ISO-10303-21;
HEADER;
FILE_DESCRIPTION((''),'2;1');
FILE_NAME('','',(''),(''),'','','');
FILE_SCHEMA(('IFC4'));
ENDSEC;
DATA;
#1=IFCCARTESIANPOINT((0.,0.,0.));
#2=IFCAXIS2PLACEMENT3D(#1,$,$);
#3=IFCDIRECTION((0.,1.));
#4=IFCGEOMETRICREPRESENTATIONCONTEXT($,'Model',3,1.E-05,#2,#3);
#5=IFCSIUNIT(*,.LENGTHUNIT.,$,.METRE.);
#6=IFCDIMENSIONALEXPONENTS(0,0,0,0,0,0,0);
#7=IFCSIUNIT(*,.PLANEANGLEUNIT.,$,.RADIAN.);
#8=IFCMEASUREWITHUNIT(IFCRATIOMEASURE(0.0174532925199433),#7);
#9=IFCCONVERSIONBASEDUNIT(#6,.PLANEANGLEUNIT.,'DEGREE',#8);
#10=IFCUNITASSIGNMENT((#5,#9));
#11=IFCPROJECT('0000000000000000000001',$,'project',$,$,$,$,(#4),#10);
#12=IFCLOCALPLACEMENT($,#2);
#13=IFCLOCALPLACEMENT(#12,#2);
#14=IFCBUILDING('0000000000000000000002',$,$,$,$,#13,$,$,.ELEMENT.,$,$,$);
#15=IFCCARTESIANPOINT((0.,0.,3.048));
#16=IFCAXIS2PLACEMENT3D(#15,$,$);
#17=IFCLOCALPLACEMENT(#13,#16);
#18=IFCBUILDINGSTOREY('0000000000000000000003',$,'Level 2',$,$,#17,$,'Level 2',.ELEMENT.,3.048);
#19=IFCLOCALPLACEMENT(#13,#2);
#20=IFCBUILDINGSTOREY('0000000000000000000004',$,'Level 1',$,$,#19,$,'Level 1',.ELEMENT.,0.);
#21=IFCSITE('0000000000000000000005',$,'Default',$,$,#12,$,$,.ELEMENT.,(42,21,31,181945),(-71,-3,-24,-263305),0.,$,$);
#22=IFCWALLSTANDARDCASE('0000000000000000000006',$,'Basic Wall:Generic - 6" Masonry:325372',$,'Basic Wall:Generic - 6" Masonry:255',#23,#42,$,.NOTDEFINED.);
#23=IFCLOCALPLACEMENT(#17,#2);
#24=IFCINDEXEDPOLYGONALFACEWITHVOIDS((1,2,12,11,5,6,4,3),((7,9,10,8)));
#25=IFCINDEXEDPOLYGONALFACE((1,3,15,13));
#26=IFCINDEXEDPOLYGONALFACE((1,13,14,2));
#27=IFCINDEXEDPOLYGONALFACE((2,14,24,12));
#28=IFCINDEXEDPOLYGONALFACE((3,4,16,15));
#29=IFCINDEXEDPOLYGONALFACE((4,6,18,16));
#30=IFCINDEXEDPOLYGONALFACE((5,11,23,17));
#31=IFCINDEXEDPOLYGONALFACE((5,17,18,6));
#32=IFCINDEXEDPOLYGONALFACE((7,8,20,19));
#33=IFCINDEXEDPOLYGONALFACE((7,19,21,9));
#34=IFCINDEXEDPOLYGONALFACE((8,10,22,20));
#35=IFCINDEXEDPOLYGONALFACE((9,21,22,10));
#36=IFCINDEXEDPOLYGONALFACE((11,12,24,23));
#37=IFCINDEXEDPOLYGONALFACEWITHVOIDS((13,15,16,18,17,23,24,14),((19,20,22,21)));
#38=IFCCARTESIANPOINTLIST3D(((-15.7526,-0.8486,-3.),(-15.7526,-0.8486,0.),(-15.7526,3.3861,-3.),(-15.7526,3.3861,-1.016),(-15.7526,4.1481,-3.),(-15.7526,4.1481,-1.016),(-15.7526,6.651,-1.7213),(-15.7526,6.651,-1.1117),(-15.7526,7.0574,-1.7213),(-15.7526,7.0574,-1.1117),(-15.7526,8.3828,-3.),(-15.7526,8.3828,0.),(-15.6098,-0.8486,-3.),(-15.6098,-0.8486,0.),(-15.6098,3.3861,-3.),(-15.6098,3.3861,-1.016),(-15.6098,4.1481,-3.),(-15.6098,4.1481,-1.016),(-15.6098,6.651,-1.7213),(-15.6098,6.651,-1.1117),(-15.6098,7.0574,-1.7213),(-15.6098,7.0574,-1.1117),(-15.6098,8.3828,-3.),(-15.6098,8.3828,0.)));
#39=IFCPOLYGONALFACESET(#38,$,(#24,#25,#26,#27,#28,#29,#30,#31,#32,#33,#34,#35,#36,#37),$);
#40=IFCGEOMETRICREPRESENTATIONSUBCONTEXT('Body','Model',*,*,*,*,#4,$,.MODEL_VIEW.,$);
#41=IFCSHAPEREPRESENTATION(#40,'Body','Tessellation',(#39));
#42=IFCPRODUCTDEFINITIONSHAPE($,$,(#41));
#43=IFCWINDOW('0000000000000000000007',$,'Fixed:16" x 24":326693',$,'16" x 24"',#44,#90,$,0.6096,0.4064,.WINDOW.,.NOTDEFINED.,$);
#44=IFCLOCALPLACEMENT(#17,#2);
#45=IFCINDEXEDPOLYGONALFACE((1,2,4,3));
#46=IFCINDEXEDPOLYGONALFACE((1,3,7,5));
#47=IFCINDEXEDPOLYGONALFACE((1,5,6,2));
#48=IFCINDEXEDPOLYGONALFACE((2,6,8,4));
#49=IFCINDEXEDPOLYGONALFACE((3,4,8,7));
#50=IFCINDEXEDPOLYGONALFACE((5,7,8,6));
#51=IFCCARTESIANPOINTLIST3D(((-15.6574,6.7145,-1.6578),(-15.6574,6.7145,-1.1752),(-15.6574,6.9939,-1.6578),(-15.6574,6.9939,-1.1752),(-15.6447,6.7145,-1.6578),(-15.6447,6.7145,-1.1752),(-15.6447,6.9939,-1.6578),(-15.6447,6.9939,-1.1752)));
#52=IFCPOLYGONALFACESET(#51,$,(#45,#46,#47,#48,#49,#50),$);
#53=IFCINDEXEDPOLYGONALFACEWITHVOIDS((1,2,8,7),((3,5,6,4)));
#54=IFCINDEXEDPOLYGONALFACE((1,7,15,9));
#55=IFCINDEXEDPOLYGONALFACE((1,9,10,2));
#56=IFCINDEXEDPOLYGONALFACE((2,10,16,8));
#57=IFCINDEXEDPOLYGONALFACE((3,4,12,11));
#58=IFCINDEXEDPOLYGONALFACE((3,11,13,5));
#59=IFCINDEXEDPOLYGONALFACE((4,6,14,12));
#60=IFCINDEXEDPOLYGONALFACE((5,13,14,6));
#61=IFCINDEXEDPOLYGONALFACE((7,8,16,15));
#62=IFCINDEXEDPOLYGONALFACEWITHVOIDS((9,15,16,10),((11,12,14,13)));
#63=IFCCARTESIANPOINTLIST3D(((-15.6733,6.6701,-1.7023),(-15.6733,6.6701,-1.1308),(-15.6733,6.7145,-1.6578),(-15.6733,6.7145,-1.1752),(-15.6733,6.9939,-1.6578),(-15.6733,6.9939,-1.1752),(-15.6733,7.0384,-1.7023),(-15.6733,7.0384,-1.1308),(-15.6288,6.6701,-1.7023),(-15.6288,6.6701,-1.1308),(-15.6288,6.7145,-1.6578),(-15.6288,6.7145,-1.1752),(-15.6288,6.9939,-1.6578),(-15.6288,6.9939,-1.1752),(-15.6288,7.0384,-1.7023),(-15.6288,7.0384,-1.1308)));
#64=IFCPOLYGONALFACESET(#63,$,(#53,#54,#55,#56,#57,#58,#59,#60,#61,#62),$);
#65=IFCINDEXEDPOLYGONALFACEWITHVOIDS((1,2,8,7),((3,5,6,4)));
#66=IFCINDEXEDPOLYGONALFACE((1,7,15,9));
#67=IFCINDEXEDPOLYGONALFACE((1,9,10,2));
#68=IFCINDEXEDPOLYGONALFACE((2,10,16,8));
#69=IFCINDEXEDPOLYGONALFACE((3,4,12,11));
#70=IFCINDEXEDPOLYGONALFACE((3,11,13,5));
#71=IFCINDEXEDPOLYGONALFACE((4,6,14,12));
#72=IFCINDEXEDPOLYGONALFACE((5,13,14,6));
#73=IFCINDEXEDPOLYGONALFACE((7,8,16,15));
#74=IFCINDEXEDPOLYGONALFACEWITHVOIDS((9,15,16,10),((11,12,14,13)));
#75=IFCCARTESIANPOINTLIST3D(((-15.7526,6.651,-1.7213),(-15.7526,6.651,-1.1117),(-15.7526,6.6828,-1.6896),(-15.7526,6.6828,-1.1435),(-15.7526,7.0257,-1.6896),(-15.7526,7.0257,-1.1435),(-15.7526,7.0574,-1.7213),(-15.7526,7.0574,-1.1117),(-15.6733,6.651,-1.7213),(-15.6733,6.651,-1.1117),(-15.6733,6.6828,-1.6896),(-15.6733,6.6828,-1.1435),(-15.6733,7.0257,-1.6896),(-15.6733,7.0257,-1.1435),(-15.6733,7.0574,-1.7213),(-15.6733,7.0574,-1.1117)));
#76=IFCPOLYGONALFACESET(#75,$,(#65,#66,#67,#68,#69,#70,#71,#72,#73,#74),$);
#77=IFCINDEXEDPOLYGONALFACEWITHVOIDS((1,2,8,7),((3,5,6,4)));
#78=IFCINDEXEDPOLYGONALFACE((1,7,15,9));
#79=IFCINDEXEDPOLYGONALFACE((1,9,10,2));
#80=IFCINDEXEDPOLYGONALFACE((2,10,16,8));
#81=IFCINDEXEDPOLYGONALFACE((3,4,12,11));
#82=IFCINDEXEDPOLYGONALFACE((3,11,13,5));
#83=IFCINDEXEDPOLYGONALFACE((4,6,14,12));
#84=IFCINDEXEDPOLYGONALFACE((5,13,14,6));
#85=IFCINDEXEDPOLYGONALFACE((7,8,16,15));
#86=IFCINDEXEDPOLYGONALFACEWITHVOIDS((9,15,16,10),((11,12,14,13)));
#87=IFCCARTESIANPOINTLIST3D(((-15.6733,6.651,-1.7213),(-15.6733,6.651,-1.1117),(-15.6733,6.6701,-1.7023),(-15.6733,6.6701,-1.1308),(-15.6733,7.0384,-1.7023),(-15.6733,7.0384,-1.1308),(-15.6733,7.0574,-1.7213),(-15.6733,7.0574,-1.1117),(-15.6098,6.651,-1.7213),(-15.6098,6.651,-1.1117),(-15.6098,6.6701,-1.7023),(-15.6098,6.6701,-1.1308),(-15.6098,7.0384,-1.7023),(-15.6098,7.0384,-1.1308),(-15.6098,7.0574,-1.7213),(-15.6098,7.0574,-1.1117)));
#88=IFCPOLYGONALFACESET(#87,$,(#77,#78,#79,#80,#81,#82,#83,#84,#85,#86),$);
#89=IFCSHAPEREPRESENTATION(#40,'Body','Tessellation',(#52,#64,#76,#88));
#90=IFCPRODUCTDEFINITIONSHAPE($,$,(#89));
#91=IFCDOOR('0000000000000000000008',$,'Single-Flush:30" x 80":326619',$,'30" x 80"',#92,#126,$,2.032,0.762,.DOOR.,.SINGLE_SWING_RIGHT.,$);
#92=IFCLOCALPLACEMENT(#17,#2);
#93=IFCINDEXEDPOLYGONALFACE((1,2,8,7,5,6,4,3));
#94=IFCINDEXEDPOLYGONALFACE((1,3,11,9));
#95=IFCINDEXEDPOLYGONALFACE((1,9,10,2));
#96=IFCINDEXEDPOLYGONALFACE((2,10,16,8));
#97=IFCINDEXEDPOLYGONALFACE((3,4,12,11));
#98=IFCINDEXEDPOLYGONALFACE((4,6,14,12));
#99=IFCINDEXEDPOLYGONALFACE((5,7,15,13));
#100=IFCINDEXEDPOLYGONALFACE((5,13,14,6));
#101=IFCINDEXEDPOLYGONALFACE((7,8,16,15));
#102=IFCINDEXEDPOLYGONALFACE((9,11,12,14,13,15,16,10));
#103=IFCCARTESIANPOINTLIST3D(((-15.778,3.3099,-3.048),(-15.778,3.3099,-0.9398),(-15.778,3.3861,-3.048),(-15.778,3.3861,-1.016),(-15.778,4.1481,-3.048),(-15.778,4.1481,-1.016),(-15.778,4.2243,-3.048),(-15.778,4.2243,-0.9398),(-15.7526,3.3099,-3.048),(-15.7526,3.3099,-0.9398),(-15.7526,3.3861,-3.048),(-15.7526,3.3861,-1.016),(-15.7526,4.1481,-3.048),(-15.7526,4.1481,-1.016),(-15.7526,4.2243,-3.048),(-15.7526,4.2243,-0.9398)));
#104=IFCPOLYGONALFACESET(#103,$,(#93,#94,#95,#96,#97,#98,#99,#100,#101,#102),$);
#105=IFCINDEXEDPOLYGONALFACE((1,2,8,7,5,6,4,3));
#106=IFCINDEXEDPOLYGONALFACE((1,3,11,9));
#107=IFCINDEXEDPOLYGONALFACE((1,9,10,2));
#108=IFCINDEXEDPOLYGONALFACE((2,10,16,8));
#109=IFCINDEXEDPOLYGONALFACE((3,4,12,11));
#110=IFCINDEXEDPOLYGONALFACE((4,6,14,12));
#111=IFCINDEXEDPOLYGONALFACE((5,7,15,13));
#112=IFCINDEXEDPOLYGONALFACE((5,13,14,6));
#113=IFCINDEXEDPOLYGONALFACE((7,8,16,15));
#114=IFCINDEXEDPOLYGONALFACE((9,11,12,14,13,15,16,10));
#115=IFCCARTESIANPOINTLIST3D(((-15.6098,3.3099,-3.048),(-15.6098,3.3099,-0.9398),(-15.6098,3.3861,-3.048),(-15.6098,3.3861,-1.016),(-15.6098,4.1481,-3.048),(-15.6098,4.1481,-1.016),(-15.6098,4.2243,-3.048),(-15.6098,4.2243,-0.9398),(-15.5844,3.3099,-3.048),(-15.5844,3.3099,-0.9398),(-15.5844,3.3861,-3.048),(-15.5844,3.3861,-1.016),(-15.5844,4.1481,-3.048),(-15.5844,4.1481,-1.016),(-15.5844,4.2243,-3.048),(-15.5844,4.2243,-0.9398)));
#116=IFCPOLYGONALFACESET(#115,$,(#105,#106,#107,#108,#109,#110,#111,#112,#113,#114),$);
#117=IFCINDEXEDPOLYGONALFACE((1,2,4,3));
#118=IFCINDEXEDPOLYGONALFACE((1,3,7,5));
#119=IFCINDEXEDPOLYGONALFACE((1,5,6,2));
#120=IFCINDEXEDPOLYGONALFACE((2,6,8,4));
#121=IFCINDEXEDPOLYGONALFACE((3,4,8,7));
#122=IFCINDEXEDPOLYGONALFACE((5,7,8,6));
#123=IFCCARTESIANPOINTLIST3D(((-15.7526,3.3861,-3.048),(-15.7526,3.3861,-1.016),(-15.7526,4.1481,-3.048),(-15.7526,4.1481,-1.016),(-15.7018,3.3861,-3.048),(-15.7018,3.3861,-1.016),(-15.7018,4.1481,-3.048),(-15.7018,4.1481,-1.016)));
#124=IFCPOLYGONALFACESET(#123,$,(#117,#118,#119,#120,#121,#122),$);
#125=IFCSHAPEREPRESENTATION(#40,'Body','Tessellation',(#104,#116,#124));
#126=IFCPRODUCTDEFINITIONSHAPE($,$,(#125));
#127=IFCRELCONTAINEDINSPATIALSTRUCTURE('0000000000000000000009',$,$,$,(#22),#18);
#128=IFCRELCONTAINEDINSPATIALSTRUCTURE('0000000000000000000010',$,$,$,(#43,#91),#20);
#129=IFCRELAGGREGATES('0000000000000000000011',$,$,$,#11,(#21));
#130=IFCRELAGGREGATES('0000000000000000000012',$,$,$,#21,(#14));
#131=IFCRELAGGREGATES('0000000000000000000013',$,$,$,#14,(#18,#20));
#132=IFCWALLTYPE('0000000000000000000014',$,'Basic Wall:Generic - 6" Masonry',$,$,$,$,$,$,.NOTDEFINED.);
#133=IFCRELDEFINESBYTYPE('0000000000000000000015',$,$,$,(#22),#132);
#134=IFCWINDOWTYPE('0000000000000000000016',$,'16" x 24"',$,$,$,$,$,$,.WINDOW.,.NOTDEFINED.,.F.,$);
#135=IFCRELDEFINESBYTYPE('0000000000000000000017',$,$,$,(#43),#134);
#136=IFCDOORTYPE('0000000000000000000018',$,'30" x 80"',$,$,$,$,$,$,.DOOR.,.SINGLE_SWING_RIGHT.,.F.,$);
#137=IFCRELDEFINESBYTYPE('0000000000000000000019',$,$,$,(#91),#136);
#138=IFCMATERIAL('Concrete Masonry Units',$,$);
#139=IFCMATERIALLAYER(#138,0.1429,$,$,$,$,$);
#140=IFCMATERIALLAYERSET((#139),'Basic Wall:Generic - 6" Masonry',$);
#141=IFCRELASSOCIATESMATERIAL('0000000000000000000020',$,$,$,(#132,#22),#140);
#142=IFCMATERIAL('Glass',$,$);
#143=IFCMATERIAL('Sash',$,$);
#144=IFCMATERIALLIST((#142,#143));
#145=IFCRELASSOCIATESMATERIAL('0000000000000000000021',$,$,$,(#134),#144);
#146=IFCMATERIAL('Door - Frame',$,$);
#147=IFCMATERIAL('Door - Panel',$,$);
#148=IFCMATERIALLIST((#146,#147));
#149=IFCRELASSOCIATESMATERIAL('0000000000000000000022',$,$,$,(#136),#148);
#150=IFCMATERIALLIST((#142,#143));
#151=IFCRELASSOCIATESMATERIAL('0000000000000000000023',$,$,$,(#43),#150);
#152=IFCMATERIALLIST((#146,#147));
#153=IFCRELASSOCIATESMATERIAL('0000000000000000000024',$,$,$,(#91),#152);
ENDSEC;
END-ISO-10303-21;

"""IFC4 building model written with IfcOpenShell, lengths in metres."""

from ifc_helpers import new_model, entity, si_unit, converted_unit, direction, frame, frame_2d, origin, place, context, subcontext, project, spatial, polyline, rectangle, outline, extrude, source, transform, mapped, material, material_list, layer, layer_set, layer_usage, type_object, type_shapes, element, fill, save


model = new_model("IFC4")

# Units and contexts
model_context = context("Model", 3, precision=1e-05, world=origin(), true_north=direction((0.0, 1.0)))
body_context = subcontext(model_context, "Body", "Model", "MODEL_VIEW")
ifc_project = project(units=[si_unit("LENGTHUNIT", "METRE"), converted_unit("PLANEANGLEUNIT", "DEGREE", entity("IfcRatioMeasure", 0.0174532925199433), si_unit("PLANEANGLEUNIT", "RADIAN"), dimensions=[0, 0, 0, 0, 0, 0, 0])], contexts=[model_context])

# Site, building, storey
site_placement = place(None, origin())
site = spatial("IfcSite", under=ifc_project, at=site_placement, Name="Default", CompositionType="ELEMENT", RefLatitude=(42, 21, 31, 181945), RefLongitude=(-71, -3, -24, -263305), RefElevation=0.0)
building_placement = place(site_placement, origin())
building = spatial("IfcBuilding", under=site, at=building_placement, CompositionType="ELEMENT")
storey_1_placement = place(building_placement, frame((0.0, 0.0, 3.048)))
storey_1 = spatial("IfcBuildingStorey", under=building, at=storey_1_placement, Name="Level 2", LongName="Level 2", CompositionType="ELEMENT", Elevation=3.048)

# Shared definitions
ifc_material_1 = material(Name="Concrete Masonry Units")
ifc_layer = layer(ifc_material_1, 0.1429)
ifc_layer_set = layer_set([ifc_layer], Name="Basic Wall:Generic - 6\" Masonry")
wall_type = type_object("IfcWallType", Name="Basic Wall:Generic - 6\" Masonry", PredefinedType="NOTDEFINED", material=ifc_layer_set)

# Shared definitions
storey_2_placement = place(building_placement, origin())
storey_2 = spatial("IfcBuildingStorey", under=building, at=storey_2_placement, Name="Level 1", LongName="Level 1", CompositionType="ELEMENT", Elevation=0.0)

# Shared definitions
ifc_material_2 = material(Name="Glass")
ifc_material_3 = material(Name="Sash")
ifc_material_list_1 = material_list([ifc_material_2, ifc_material_3])
window_type = type_object("IfcWindowType", Name="16\" x 24\"", ParameterTakesPrecedence=False, PartitioningType="NOTDEFINED", PredefinedType="WINDOW", material=ifc_material_list_1)
shared_shape_1 = source(origin(), body_context, "Body", "SweptSolid", [
    extrude(rectangle(XDim=0.0127, YDim=0.2794, at=frame_2d((0.0, 0.0), x_axis=(1.0, 0.0))), frame((0.2032, 0.1016, 0.0635), z_axis=(0.0, 0.0, 1.0), x_axis=(0.0, 1.0, 0.0)), (0.0, 0.0, 1.0), 0.4826),
    extrude(outline(polyline([(-0.1841, -0.2858), (0.1841, -0.2858), (0.1841, 0.2858), (-0.1841, 0.2858), (-0.1841, -0.2858)]), holes=[polyline([(-0.1397, -0.2413), (-0.1397, 0.2413), (0.1397, 0.2413), (0.1397, -0.2413), (-0.1397, -0.2413)])]), frame((0.2032, 0.0794, 0.3048), z_axis=(0.0, 1.0, 0.0), x_axis=(1.0, 0.0, 0.0)), (0.0, 0.0, 1.0), 0.0445),
    extrude(outline(polyline([(-0.2032, -0.3048), (0.2032, -0.3048), (0.2032, 0.3048), (-0.2032, 0.3048), (-0.2032, -0.3048)]), holes=[polyline([(-0.1715, -0.273), (-0.1715, 0.2731), (0.1714, 0.2731), (0.1714, -0.273), (-0.1715, -0.273)])]), frame((0.2032, 0.0, 0.3048), z_axis=(0.0, 1.0, 0.0), x_axis=(1.0, 0.0, 0.0)), (0.0, 0.0, 1.0), 0.0794),
    extrude(outline(polyline([(-0.3048, -0.2032), (0.3048, -0.2032), (0.3048, 0.2032), (-0.3048, 0.2032), (-0.3048, -0.2032)]), holes=[polyline([(-0.2857, -0.1841), (-0.2857, 0.1842), (0.2858, 0.1842), (0.2858, -0.1841), (-0.2857, -0.1841)])]), frame((0.2032, 0.0794, 0.3048), z_axis=(0.0, 1.0, 0.0), x_axis=(0.0, 0.0, -1.0)), (0.0, 0.0, 1.0), 0.0635),
])
type_shapes(window_type, [shared_shape_1])

# Shared definitions
ifc_material_4 = material(Name="Door - Frame")
ifc_material_5 = material(Name="Door - Panel")
ifc_material_list_2 = material_list([ifc_material_4, ifc_material_5])
door_type = type_object("IfcDoorType", Name="30\" x 80\"", OperationType="SINGLE_SWING_RIGHT", ParameterTakesPrecedence=False, PredefinedType="DOOR", material=ifc_material_list_2)
shared_shape_2 = source(origin(), body_context, "Body", "SweptSolid", [
    extrude(outline(polyline([(-0.4572, -1.0732), (0.4572, -1.0732), (0.4572, 1.0351), (0.381, 1.0351), (0.381, -0.997), (-0.381, -0.997), (-0.381, 1.0351), (-0.4572, 1.0351), (-0.4572, -1.0732)])), frame((0.381, 0.1429, 1.0351), z_axis=(0.0, 1.0, 0.0), x_axis=(1.0, 0.0, 0.0)), (0.0, 0.0, 1.0), 0.0254),
    extrude(outline(polyline([(-1.0732, -0.4572), (1.0351, -0.4572), (1.0351, -0.381), (-0.997, -0.381), (-0.997, 0.381), (1.0351, 0.381), (1.0351, 0.4572), (-1.0732, 0.4572), (-1.0732, -0.4572)])), frame((0.381, -0.0254, 1.0351), z_axis=(0.0, 1.0, 0.0), x_axis=(0.0, 0.0, -1.0)), (0.0, 0.0, 1.0), 0.0254),
    extrude(rectangle(XDim=0.0508, YDim=0.762, at=frame_2d((0.0, 0.0), x_axis=(1.0, 0.0))), frame((0.381, 0.1175, 0.0), z_axis=(0.0, 0.0, 1.0), x_axis=(0.0, 1.0, 0.0)), (0.0, 0.0, 1.0), 2.032),
])
type_shapes(door_type, [shared_shape_2])

# Wall, openings, window, door
ifc_layer_usage_1 = layer_usage(ifc_layer_set, "AXIS2", "NEGATIVE", 0.0714)
wall_1_placement = place(storey_1_placement, frame((-15.6812, -0.8486, -3.0), z_axis=(0.0, 0.0, 1.0), x_axis=(0.0, 1.0, 0.0)))
wall_1 = element("IfcWallStandardCase", 1, at=wall_1_placement, inside=storey_1, type_object=wall_type, material=ifc_layer_usage_1, Name="Basic Wall:Generic - 6\" Masonry:325372", ObjectType="Basic Wall:Generic - 6\" Masonry:255", PredefinedType="NOTDEFINED", context=body_context, shape_type="SweptSolid", body=[
    extrude(rectangle(XDim=9.2314, YDim=0.1429, at=frame_2d((4.6157, 0.0), x_axis=(-1.0, 0.0))), origin(), (0.0, 0.0, 1.0), 3.0),
])
opening_1_placement = place(wall_1_placement, frame((4.2347, -0.0714, -0.048)))
opening_1 = element("IfcOpeningElement", 2, at=opening_1_placement, cuts=wall_1, ObjectType="Opening", PredefinedType="OPENING", context=body_context, shape_type="SweptSolid", body=[
    extrude(rectangle(XDim=0.762, YDim=2.032, at=frame_2d((1.016, 0.381), x_axis=(0.0, 1.0))), frame((0.0, 0.0, 0.0), z_axis=(0.0, 1.0, 0.0), x_axis=(0.0, 0.0, 1.0)), (0.0, 0.0, 1.0), 0.1429),
])
opening_2_placement = place(wall_1_placement, frame((7.906, 0.0714, 1.2787)))
opening_2 = element("IfcOpeningElement", 3, at=opening_2_placement, cuts=wall_1, ObjectType="Opening", PredefinedType="OPENING", context=body_context, shape_type="SweptSolid", body=[
    extrude(rectangle(XDim=0.6096, YDim=0.4064, at=frame_2d((0.3048, 0.2032), x_axis=(-1.0, 0.0))), frame((0.0, 0.0, 0.0), z_axis=(0.0, -1.0, 0.0), x_axis=(0.0, 0.0, 1.0)), (0.0, 0.0, 1.0), 0.1429),
])
ifc_material_list_3 = material_list([ifc_material_2, ifc_material_3])
window_1_placement = place(opening_2_placement, frame((0.0, 0.0, 0.0), z_axis=(0.0, 0.0, 1.0), x_axis=(-1.0, 0.0, 0.0)))
window_1 = element("IfcWindow", 4, at=window_1_placement, inside=storey_2, type_object=window_type, material=ifc_material_list_3, Name="Fixed:16\" x 24\":326693", ObjectType="16\" x 24\"", OverallHeight=0.6096, OverallWidth=0.4064, PartitioningType="NOTDEFINED", PredefinedType="WINDOW", context=body_context, shape_type="MappedRepresentation", body=[
    mapped(shared_shape_1, transform((0.0, 0.0, 0.0), scale=1.0)),
])
fill(opening_2, window_1)
ifc_material_list_4 = material_list([ifc_material_4, ifc_material_5])
door_1_placement = place(opening_1_placement, origin())
door_1 = element("IfcDoor", 5, at=door_1_placement, inside=storey_2, type_object=door_type, material=ifc_material_list_4, Name="Single-Flush:30\" x 80\":326619", ObjectType="30\" x 80\"", OperationType="SINGLE_SWING_RIGHT", OverallHeight=2.032, OverallWidth=0.762, PredefinedType="DOOR", context=body_context, shape_type="MappedRepresentation", body=[
    mapped(shared_shape_2, transform((0.0, 0.0, 0.0), scale=1.0)),
])
fill(opening_1, door_1)

save(model, "model.ifc")
